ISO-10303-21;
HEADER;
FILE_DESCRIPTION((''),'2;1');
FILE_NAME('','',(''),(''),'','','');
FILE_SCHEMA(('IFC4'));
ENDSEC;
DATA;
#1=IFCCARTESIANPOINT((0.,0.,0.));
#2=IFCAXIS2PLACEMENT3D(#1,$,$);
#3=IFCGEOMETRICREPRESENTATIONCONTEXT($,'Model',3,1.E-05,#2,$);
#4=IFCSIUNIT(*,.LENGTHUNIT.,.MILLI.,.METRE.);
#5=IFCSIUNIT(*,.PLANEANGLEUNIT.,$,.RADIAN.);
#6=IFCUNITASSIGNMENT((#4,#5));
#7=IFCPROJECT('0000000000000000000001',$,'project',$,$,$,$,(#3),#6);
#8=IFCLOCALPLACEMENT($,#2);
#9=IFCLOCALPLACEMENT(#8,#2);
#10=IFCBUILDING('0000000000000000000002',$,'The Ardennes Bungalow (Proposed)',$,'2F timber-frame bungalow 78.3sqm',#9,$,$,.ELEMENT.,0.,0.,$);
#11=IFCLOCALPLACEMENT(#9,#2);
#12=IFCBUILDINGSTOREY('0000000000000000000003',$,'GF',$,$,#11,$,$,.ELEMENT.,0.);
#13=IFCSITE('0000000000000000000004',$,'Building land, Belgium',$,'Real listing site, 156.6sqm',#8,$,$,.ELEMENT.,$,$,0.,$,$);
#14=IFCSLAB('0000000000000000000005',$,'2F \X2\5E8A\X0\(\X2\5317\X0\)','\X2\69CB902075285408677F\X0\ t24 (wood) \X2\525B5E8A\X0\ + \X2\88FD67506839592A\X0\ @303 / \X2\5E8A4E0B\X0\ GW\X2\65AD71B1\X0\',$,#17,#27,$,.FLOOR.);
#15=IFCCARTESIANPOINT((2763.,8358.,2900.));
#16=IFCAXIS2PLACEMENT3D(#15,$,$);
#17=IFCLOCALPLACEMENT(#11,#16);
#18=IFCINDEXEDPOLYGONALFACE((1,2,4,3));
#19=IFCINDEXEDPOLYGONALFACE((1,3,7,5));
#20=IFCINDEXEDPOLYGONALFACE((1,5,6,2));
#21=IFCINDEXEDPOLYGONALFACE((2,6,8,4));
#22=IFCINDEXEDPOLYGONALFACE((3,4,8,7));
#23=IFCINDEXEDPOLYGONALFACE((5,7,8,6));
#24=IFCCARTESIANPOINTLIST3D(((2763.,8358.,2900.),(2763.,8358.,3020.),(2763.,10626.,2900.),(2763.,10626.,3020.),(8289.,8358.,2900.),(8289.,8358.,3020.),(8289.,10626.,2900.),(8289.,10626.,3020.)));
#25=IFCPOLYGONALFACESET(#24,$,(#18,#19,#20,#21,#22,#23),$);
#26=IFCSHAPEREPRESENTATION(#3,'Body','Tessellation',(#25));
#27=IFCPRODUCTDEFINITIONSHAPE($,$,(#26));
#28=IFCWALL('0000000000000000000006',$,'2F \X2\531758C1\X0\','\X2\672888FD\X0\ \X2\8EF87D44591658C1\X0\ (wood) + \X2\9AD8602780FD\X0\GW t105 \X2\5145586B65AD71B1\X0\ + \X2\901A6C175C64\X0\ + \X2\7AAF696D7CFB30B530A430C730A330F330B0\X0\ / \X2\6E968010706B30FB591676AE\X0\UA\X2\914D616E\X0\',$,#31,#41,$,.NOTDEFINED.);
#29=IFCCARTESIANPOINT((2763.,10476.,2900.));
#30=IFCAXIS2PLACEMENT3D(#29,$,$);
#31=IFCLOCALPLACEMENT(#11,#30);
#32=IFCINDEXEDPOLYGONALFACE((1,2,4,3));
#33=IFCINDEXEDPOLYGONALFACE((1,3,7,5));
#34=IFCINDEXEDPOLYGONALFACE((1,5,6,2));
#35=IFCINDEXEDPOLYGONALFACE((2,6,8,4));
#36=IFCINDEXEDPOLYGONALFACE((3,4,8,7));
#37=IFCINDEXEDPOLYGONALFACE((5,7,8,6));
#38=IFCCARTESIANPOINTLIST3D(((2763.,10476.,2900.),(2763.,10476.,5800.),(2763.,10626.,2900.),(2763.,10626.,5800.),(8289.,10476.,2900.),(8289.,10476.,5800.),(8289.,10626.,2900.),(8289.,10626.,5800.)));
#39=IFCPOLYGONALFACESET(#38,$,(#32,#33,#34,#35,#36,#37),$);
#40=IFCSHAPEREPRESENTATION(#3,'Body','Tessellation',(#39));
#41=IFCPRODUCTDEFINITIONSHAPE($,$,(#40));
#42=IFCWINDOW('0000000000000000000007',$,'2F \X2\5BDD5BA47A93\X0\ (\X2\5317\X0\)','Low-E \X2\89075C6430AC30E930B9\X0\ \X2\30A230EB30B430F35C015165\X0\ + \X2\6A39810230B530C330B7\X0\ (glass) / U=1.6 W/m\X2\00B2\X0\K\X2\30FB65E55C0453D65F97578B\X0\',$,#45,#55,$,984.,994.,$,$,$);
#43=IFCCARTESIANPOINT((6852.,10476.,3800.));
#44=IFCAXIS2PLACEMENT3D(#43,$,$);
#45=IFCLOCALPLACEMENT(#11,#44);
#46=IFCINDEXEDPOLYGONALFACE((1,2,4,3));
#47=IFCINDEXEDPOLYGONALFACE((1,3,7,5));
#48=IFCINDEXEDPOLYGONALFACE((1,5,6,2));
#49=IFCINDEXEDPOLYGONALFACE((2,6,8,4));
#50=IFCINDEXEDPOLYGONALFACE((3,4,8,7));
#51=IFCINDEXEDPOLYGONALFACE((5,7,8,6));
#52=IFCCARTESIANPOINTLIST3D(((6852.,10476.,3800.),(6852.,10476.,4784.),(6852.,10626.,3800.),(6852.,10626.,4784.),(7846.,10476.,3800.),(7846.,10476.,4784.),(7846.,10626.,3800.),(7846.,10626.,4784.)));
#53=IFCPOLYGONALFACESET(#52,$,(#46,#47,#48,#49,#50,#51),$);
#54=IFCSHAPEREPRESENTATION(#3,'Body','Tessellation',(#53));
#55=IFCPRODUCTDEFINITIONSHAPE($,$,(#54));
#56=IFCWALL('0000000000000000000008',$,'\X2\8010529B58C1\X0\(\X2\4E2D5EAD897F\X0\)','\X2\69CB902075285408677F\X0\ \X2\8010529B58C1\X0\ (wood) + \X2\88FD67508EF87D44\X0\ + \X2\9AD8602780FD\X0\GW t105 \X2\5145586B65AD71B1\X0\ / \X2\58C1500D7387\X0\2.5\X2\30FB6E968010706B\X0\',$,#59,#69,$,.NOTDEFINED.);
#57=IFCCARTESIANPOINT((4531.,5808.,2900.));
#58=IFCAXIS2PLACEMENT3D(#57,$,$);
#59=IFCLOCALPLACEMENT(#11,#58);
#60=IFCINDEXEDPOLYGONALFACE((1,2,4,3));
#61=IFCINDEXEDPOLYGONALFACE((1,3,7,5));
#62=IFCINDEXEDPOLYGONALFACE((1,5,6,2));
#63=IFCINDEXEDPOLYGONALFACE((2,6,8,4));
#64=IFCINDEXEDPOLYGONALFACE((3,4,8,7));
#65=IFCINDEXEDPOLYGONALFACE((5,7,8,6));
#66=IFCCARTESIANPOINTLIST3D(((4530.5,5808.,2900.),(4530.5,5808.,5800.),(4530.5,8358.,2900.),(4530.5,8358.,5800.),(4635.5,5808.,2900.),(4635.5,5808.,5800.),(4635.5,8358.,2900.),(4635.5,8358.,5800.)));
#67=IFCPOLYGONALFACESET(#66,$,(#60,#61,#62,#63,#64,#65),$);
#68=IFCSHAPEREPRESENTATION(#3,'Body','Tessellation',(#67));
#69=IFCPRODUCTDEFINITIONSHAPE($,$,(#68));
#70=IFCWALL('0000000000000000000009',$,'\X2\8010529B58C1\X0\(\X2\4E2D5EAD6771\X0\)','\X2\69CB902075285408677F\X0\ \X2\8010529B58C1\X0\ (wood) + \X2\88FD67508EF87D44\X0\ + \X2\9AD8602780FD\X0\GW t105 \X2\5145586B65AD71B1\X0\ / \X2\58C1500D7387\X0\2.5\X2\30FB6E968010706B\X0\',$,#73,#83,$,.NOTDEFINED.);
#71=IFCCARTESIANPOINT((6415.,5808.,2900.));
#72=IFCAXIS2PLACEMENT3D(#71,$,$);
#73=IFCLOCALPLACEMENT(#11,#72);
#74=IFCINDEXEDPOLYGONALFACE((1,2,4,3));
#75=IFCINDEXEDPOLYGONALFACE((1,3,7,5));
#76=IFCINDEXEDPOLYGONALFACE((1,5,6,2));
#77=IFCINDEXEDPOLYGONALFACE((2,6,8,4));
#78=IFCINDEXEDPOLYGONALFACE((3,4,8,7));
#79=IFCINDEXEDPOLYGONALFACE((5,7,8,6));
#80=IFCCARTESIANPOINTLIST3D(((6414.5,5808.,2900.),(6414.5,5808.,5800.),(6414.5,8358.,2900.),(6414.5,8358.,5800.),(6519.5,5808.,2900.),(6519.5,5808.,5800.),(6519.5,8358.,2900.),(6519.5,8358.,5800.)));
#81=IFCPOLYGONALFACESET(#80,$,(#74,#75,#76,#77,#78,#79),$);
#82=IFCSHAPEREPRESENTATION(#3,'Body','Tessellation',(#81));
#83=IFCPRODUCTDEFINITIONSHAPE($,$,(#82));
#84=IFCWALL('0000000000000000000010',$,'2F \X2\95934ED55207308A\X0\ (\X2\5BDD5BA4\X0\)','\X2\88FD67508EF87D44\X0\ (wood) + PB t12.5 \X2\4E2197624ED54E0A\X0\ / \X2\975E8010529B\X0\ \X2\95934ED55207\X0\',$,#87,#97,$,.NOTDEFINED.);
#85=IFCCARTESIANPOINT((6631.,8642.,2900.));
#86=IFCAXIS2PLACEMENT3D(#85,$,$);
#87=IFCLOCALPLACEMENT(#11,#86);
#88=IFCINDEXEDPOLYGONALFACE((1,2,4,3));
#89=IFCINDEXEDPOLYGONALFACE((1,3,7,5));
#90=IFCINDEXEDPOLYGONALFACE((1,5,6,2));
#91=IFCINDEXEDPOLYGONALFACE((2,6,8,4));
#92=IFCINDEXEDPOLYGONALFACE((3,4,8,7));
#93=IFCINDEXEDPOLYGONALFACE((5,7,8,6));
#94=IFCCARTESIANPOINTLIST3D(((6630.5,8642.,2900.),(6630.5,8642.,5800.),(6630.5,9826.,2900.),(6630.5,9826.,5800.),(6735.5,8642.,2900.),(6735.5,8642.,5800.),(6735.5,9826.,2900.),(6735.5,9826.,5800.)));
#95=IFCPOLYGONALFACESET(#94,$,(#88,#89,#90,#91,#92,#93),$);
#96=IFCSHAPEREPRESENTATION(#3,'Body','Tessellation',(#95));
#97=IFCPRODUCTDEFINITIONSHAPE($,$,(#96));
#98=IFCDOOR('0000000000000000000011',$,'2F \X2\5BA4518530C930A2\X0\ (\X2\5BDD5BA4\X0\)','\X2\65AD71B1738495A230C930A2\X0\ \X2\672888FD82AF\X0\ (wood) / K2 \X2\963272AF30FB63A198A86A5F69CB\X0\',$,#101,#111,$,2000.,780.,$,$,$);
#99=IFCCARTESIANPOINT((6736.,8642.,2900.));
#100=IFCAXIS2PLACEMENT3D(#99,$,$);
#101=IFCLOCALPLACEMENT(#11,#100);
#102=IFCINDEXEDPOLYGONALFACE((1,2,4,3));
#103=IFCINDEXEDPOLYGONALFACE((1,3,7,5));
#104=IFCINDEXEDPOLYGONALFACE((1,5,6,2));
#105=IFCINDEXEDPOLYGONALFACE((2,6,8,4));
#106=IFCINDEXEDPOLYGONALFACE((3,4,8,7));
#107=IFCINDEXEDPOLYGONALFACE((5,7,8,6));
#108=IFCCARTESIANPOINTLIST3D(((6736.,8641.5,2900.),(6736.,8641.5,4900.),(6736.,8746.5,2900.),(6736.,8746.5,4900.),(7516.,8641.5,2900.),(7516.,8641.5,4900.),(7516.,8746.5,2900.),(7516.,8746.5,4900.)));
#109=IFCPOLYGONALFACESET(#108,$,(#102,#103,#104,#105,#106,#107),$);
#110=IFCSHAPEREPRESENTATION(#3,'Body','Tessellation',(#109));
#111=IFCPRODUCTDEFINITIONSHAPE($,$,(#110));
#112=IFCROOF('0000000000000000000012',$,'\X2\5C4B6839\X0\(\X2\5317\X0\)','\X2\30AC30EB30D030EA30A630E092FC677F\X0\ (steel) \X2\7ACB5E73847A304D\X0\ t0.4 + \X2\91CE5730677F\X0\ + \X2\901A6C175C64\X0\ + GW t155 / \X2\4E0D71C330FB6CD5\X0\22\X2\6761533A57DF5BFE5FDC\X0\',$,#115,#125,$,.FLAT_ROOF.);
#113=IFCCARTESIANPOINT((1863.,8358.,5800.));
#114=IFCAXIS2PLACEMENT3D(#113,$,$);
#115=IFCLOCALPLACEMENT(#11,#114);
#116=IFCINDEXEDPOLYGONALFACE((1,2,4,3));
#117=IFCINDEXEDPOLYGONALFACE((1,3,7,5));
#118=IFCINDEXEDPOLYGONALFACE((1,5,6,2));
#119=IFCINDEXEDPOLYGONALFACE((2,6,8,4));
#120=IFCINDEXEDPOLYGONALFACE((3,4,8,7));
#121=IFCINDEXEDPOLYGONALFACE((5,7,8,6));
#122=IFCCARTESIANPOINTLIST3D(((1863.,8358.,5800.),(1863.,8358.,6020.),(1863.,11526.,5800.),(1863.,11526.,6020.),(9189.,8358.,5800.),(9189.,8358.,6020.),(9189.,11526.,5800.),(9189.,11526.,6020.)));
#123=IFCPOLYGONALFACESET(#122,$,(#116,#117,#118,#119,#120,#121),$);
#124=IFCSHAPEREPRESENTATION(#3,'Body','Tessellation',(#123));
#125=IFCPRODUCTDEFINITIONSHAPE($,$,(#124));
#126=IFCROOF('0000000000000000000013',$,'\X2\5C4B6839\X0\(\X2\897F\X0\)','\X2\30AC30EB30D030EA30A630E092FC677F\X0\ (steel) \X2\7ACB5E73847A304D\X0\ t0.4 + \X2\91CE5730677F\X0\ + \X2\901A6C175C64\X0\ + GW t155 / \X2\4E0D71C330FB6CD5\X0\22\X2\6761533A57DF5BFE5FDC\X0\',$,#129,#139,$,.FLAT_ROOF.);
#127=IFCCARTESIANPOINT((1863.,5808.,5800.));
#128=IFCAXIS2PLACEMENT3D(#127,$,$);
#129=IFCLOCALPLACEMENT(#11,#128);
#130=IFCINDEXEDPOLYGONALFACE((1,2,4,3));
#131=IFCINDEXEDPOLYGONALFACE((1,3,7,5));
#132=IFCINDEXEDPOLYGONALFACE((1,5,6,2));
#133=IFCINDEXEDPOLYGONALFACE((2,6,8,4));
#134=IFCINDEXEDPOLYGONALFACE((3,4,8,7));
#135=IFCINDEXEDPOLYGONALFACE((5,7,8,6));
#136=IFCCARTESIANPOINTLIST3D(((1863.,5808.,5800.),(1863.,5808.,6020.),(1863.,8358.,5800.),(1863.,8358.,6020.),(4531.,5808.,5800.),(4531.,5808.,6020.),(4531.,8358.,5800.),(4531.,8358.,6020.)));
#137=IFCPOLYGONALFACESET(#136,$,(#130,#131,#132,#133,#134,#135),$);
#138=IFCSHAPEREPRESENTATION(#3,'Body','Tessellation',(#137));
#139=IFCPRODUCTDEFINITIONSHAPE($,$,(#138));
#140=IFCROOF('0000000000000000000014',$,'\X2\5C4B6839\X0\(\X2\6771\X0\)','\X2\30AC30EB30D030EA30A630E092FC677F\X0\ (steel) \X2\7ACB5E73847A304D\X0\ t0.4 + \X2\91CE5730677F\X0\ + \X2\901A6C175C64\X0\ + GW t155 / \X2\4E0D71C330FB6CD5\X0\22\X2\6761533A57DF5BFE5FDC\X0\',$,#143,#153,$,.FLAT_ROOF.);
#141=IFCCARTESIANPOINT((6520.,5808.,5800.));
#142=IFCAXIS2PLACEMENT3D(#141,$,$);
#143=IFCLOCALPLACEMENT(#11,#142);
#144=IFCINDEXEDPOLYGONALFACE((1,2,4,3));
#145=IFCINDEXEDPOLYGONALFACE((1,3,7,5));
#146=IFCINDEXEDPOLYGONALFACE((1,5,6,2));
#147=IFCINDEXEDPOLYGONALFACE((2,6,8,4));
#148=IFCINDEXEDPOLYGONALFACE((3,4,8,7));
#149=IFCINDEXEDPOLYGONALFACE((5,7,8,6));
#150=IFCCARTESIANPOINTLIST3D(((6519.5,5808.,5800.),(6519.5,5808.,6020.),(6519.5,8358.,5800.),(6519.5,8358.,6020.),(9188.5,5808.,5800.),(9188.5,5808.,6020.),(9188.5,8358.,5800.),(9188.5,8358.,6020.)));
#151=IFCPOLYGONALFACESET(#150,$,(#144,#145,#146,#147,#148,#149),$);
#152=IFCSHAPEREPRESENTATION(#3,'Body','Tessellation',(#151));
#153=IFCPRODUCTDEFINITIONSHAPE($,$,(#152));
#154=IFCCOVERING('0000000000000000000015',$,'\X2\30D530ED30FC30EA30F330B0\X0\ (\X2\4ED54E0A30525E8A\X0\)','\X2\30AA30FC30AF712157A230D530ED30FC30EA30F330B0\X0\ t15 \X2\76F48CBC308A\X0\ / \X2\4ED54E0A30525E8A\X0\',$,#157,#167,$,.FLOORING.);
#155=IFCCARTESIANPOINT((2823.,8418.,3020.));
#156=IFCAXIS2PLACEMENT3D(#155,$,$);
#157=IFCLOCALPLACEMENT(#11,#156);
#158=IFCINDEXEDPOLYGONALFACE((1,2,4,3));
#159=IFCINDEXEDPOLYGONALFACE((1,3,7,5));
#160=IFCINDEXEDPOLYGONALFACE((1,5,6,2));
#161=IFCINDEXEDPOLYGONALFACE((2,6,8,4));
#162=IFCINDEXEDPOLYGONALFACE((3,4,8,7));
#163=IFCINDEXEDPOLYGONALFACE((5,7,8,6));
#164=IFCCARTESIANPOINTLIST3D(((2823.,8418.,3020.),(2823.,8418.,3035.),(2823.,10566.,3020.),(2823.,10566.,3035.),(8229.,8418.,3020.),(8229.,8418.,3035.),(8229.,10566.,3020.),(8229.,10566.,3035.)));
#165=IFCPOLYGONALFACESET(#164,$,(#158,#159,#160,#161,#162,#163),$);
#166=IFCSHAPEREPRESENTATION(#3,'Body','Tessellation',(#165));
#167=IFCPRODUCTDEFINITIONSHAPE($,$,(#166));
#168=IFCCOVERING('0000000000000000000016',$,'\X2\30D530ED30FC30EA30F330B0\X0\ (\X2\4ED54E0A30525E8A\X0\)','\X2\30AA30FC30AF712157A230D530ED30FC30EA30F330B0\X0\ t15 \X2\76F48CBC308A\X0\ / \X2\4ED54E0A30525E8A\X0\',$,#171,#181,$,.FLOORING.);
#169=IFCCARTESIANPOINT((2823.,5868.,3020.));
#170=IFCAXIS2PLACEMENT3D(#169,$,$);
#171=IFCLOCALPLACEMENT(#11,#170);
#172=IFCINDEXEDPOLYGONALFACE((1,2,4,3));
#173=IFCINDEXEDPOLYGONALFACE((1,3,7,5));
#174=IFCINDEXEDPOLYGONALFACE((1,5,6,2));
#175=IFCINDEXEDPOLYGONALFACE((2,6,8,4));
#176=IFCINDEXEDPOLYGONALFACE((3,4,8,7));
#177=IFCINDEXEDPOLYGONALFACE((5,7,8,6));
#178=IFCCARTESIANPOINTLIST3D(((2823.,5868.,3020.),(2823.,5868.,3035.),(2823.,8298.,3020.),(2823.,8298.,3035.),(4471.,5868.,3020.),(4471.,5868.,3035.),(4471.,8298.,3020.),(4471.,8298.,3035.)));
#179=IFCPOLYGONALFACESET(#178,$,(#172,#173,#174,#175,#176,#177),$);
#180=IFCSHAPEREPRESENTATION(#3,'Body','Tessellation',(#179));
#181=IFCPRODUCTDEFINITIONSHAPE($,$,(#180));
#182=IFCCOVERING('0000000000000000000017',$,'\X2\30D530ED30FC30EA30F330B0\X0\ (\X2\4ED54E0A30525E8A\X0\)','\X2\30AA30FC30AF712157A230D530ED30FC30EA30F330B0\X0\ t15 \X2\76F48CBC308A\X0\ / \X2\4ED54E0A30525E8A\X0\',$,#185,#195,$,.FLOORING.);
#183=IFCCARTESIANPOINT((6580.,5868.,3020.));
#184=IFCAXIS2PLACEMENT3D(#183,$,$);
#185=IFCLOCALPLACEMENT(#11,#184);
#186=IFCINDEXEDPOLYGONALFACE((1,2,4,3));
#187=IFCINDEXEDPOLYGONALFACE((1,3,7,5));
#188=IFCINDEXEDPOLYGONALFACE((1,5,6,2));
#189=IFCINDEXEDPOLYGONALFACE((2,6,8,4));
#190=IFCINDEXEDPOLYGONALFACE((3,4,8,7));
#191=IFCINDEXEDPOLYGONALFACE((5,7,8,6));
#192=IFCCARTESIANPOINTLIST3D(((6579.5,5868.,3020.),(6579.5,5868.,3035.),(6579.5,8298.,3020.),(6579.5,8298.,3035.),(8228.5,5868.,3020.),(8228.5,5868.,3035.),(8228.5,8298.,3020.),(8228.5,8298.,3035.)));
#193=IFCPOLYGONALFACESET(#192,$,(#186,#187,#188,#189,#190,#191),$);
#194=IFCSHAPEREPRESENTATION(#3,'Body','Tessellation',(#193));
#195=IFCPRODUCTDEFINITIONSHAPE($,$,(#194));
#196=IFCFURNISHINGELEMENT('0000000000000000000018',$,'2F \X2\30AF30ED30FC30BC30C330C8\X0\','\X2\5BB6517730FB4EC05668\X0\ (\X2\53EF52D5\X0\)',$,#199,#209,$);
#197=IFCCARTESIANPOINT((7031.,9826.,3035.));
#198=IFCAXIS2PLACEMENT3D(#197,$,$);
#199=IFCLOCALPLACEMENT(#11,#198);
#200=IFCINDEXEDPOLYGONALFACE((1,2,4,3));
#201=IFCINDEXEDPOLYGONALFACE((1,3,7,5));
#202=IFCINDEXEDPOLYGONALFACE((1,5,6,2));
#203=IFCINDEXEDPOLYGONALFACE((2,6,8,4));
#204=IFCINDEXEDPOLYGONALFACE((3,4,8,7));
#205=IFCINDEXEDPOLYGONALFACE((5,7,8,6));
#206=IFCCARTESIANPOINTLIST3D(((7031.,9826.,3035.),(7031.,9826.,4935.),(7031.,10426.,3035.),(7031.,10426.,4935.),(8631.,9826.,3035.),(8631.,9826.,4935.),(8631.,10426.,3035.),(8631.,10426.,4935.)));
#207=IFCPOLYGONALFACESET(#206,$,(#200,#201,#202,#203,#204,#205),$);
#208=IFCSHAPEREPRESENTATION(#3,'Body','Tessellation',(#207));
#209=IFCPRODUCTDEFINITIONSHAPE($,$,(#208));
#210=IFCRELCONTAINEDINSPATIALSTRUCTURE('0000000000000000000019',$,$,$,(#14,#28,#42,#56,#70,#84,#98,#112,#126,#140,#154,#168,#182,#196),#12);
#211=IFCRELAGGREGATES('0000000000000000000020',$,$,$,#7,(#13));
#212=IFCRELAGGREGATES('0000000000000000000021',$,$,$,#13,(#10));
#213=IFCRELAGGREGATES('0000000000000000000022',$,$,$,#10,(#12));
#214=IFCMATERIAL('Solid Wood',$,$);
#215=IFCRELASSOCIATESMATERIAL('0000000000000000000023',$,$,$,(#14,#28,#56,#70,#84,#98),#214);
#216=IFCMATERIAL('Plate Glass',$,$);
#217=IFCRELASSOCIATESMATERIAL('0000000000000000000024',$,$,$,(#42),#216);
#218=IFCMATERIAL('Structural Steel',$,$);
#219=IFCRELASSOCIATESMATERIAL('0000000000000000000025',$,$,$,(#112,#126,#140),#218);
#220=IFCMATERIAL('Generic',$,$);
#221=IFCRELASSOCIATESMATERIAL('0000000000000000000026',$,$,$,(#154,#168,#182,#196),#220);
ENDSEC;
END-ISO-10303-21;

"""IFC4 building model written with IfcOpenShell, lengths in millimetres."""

from ifc_helpers import new_model, si_unit, frame, frame_2d, origin, place, context, project, spatial, rectangle, extrude, material, element, fill, save


model = new_model("IFC4")

# Units and contexts
model_context = context("Model", 3, precision=1e-05, world=origin())
ifc_project = project(units=[si_unit("LENGTHUNIT", "METRE", prefix="MILLI"), si_unit("PLANEANGLEUNIT", "RADIAN")], contexts=[model_context])

# Site, building, storey
site_placement = place(None, origin())
site = spatial("IfcSite", under=ifc_project, at=site_placement, Name="Building land, Belgium", ObjectType="Real listing site, 156.6sqm", CompositionType="ELEMENT", RefElevation=0.0)
building_placement = place(site_placement, origin())
building = spatial("IfcBuilding", under=site, at=building_placement, Name="The Ardennes Bungalow (Proposed)", ObjectType="2F timber-frame bungalow 78.3sqm", CompositionType="ELEMENT", ElevationOfRefHeight=0.0, ElevationOfTerrain=0.0)
storey_placement = place(building_placement, origin())
storey = spatial("IfcBuildingStorey", under=building, at=storey_placement, Name="GF", CompositionType="ELEMENT", Elevation=0.0)

# Slab
ifc_material_1 = material(Name="Solid Wood")
slab_placement = place(storey_placement, frame((2763.0, 8358.0, 2900.0)))
element("IfcSlab", 1, at=slab_placement, inside=storey, material=ifc_material_1, Name="2F 床(北)", Description="構造用合板 t24 (wood) 剛床 + 製材根太 @303 / 床下 GW断熱", PredefinedType="FLOOR", context=model_context, shape_type="SweptSolid", body=[
    extrude(rectangle(XDim=5526.0, YDim=2268.0, at=frame_2d((2763.0, 1134.0))), frame((2763.0, 8358.0, 2900.0)), (0.0, 0.0, 1.0), 120.0),
])

# Wall, opening, window
wall_1_placement = place(storey_placement, frame((2763.0, 10476.0, 2900.0)))
wall_1 = element("IfcWall", 2, at=wall_1_placement, inside=storey, material=ifc_material_1, Name="2F 北壁", Description="木製 軸組外壁 (wood) + 高性能GW t105 充填断熱 + 通気層 + 窯業系サイディング / 準耐火・外皮UA配慮", PredefinedType="NOTDEFINED", context=model_context, shape_type="SweptSolid", body=[
    extrude(rectangle(XDim=5526.0, YDim=150.0, at=frame_2d((2763.0, 75.0))), frame((2763.0, 10476.0, 2900.0)), (0.0, 0.0, 1.0), 2900.0),
])
opening_1_placement = place(storey_placement, frame((6852.0, 10476.0, 3800.0)))
opening_1 = element("IfcOpeningElement", 3, at=opening_1_placement, cuts=wall_1, PredefinedType="NOTDEFINED", context=model_context, shape_type="SweptSolid", body=[
    extrude(rectangle(XDim=994.0, YDim=150.0, at=frame_2d((497.0, 75.0))), frame((6852.0, 10476.0, 3800.0)), (0.0, 0.0, 1.0), 984.0),
])
ifc_material_2 = material(Name="Plate Glass")
window_1_placement = place(storey_placement, frame((6852.0, 10476.0, 3800.0)))
window_1 = element("IfcWindow", 4, at=window_1_placement, inside=storey, material=ifc_material_2, Name="2F 寝室窓 (北)", Description="Low-E 複層ガラス アルゴン封入 + 樹脂サッシ (glass) / U=1.6 W/m²K・日射取得型", OverallHeight=984.0, OverallWidth=994.0, context=model_context, shape_type="SweptSolid", body=[
    extrude(rectangle(XDim=994.0, YDim=150.0, at=frame_2d((497.0, 75.0))), frame((6852.0, 10476.0, 3800.0)), (0.0, 0.0, 1.0), 984.0),
])
fill(opening_1, window_1)

# Walls
wall_2_placement = place(storey_placement, frame((4531.0, 5808.0, 2900.0)))
element("IfcWall", 5, at=wall_2_placement, inside=storey, material=ifc_material_1, Name="耐力壁(中庭西)", Description="構造用合板 耐力壁 (wood) + 製材軸組 + 高性能GW t105 充填断熱 / 壁倍率2.5・準耐火", PredefinedType="NOTDEFINED", context=model_context, shape_type="SweptSolid", body=[
    extrude(rectangle(XDim=105.0, YDim=2550.0, at=frame_2d((52.0, 1275.0))), frame((4531.0, 5808.0, 2900.0)), (0.0, 0.0, 1.0), 2900.0),
])
wall_3_placement = place(storey_placement, frame((6415.0, 5808.0, 2900.0)))
element("IfcWall", 6, at=wall_3_placement, inside=storey, material=ifc_material_1, Name="耐力壁(中庭東)", Description="構造用合板 耐力壁 (wood) + 製材軸組 + 高性能GW t105 充填断熱 / 壁倍率2.5・準耐火", PredefinedType="NOTDEFINED", context=model_context, shape_type="SweptSolid", body=[
    extrude(rectangle(XDim=105.0, YDim=2550.0, at=frame_2d((52.0, 1275.0))), frame((6415.0, 5808.0, 2900.0)), (0.0, 0.0, 1.0), 2900.0),
])
wall_4_placement = place(storey_placement, frame((6631.0, 8642.0, 2900.0)))
element("IfcWall", 7, at=wall_4_placement, inside=storey, material=ifc_material_1, Name="2F 間仕切り (寝室)", Description="製材軸組 (wood) + PB t12.5 両面仕上 / 非耐力 間仕切", PredefinedType="NOTDEFINED", context=model_context, shape_type="SweptSolid", body=[
    extrude(rectangle(XDim=105.0, YDim=1184.0, at=frame_2d((52.0, 592.0))), frame((6631.0, 8642.0, 2900.0)), (0.0, 0.0, 1.0), 2900.0),
])

# Door
door_placement = place(storey_placement, frame((6736.0, 8642.0, 2900.0)))
element("IfcDoor", 8, at=door_placement, inside=storey, material=ifc_material_1, Name="2F 室内ドア (寝室)", Description="断熱玄関ドア 木製芯 (wood) / K2 防犯・採風機構", OverallHeight=2000.0, OverallWidth=780.0, context=model_context, shape_type="SweptSolid", body=[
    extrude(rectangle(XDim=780.0, YDim=105.0, at=frame_2d((390.0, 52.0))), frame((6736.0, 8642.0, 2900.0)), (0.0, 0.0, 1.0), 2000.0),
])

# Roofs
ifc_material_3 = material(Name="Structural Steel")
for number, where, name in (
    (9, (1863.0, 8358.0, 5800.0), "屋根(北)"),
):
    element("IfcRoof", number, at=place(storey_placement, frame(where)), inside=storey, material=ifc_material_3, Name=name, Description="ガルバリウム鋼板 (steel) 立平葺き t0.4 + 野地板 + 通気層 + GW t155 / 不燃・法22条区域対応", PredefinedType="FLAT_ROOF", context=model_context, shape_type="SweptSolid", body=[
        extrude(rectangle(XDim=7326.0, YDim=3168.0, at=frame_2d((3663.0, 1584.0))), frame((1863.0, 8358.0, 5800.0)), (0.0, 0.0, 1.0), 220.0),
    ])
roof_1_placement = place(storey_placement, frame((1863.0, 5808.0, 5800.0)))
element("IfcRoof", 10, at=roof_1_placement, inside=storey, material=ifc_material_3, Name="屋根(西)", Description="ガルバリウム鋼板 (steel) 立平葺き t0.4 + 野地板 + 通気層 + GW t155 / 不燃・法22条区域対応", PredefinedType="FLAT_ROOF", context=model_context, shape_type="SweptSolid", body=[
    extrude(rectangle(XDim=2668.0, YDim=2550.0, at=frame_2d((1334.0, 1275.0))), frame((1863.0, 5808.0, 5800.0)), (0.0, 0.0, 1.0), 220.0),
])
roof_2_placement = place(storey_placement, frame((6520.0, 5808.0, 5800.0)))
element("IfcRoof", 11, at=roof_2_placement, inside=storey, material=ifc_material_3, Name="屋根(東)", Description="ガルバリウム鋼板 (steel) 立平葺き t0.4 + 野地板 + 通気層 + GW t155 / 不燃・法22条区域対応", PredefinedType="FLAT_ROOF", context=model_context, shape_type="SweptSolid", body=[
    extrude(rectangle(XDim=2669.0, YDim=2550.0, at=frame_2d((1334.0, 1275.0))), frame((6520.0, 5808.0, 5800.0)), (0.0, 0.0, 1.0), 220.0),
])

# Coverings
ifc_material_4 = material(Name="Generic")
covering_1_placement = place(storey_placement, frame((2823.0, 8418.0, 3020.0)))
element("IfcCovering", 12, at=covering_1_placement, inside=storey, material=ifc_material_4, Name="フローリング (仕上げ床)", Description="オーク無垢フローリング t15 直貼り / 仕上げ床", PredefinedType="FLOORING", context=model_context, shape_type="SweptSolid", body=[
    extrude(rectangle(XDim=5406.0, YDim=2148.0, at=frame_2d((2703.0, 1074.0))), frame((2823.0, 8418.0, 3020.0)), (0.0, 0.0, 1.0), 15.0),
])
covering_2_placement = place(storey_placement, frame((2823.0, 5868.0, 3020.0)))
element("IfcCovering", 13, at=covering_2_placement, inside=storey, material=ifc_material_4, Name="フローリング (仕上げ床)", Description="オーク無垢フローリング t15 直貼り / 仕上げ床", PredefinedType="FLOORING", context=model_context, shape_type="SweptSolid", body=[
    extrude(rectangle(XDim=1648.0, YDim=2430.0, at=frame_2d((824.0, 1215.0))), frame((2823.0, 5868.0, 3020.0)), (0.0, 0.0, 1.0), 15.0),
])
covering_3_placement = place(storey_placement, frame((6580.0, 5868.0, 3020.0)))
element("IfcCovering", 14, at=covering_3_placement, inside=storey, material=ifc_material_4, Name="フローリング (仕上げ床)", Description="オーク無垢フローリング t15 直貼り / 仕上げ床", PredefinedType="FLOORING", context=model_context, shape_type="SweptSolid", body=[
    extrude(rectangle(XDim=1649.0, YDim=2430.0, at=frame_2d((824.0, 1215.0))), frame((6580.0, 5868.0, 3020.0)), (0.0, 0.0, 1.0), 15.0),
])

# Furnishing element
furnishing_1_placement = place(storey_placement, frame((7031.0, 9826.0, 3035.0)))
element("IfcFurnishingElement", 15, at=furnishing_1_placement, inside=storey, material=ifc_material_4, Name="2F クローゼット", Description="家具・什器 (可動)", context=model_context, shape_type="SweptSolid", body=[
    extrude(rectangle(XDim=1600.0, YDim=600.0, at=frame_2d((800.0, 300.0))), frame((7031.0, 9826.0, 3035.0)), (0.0, 0.0, 1.0), 1900.0),
])

save(model, "model.ifc")
